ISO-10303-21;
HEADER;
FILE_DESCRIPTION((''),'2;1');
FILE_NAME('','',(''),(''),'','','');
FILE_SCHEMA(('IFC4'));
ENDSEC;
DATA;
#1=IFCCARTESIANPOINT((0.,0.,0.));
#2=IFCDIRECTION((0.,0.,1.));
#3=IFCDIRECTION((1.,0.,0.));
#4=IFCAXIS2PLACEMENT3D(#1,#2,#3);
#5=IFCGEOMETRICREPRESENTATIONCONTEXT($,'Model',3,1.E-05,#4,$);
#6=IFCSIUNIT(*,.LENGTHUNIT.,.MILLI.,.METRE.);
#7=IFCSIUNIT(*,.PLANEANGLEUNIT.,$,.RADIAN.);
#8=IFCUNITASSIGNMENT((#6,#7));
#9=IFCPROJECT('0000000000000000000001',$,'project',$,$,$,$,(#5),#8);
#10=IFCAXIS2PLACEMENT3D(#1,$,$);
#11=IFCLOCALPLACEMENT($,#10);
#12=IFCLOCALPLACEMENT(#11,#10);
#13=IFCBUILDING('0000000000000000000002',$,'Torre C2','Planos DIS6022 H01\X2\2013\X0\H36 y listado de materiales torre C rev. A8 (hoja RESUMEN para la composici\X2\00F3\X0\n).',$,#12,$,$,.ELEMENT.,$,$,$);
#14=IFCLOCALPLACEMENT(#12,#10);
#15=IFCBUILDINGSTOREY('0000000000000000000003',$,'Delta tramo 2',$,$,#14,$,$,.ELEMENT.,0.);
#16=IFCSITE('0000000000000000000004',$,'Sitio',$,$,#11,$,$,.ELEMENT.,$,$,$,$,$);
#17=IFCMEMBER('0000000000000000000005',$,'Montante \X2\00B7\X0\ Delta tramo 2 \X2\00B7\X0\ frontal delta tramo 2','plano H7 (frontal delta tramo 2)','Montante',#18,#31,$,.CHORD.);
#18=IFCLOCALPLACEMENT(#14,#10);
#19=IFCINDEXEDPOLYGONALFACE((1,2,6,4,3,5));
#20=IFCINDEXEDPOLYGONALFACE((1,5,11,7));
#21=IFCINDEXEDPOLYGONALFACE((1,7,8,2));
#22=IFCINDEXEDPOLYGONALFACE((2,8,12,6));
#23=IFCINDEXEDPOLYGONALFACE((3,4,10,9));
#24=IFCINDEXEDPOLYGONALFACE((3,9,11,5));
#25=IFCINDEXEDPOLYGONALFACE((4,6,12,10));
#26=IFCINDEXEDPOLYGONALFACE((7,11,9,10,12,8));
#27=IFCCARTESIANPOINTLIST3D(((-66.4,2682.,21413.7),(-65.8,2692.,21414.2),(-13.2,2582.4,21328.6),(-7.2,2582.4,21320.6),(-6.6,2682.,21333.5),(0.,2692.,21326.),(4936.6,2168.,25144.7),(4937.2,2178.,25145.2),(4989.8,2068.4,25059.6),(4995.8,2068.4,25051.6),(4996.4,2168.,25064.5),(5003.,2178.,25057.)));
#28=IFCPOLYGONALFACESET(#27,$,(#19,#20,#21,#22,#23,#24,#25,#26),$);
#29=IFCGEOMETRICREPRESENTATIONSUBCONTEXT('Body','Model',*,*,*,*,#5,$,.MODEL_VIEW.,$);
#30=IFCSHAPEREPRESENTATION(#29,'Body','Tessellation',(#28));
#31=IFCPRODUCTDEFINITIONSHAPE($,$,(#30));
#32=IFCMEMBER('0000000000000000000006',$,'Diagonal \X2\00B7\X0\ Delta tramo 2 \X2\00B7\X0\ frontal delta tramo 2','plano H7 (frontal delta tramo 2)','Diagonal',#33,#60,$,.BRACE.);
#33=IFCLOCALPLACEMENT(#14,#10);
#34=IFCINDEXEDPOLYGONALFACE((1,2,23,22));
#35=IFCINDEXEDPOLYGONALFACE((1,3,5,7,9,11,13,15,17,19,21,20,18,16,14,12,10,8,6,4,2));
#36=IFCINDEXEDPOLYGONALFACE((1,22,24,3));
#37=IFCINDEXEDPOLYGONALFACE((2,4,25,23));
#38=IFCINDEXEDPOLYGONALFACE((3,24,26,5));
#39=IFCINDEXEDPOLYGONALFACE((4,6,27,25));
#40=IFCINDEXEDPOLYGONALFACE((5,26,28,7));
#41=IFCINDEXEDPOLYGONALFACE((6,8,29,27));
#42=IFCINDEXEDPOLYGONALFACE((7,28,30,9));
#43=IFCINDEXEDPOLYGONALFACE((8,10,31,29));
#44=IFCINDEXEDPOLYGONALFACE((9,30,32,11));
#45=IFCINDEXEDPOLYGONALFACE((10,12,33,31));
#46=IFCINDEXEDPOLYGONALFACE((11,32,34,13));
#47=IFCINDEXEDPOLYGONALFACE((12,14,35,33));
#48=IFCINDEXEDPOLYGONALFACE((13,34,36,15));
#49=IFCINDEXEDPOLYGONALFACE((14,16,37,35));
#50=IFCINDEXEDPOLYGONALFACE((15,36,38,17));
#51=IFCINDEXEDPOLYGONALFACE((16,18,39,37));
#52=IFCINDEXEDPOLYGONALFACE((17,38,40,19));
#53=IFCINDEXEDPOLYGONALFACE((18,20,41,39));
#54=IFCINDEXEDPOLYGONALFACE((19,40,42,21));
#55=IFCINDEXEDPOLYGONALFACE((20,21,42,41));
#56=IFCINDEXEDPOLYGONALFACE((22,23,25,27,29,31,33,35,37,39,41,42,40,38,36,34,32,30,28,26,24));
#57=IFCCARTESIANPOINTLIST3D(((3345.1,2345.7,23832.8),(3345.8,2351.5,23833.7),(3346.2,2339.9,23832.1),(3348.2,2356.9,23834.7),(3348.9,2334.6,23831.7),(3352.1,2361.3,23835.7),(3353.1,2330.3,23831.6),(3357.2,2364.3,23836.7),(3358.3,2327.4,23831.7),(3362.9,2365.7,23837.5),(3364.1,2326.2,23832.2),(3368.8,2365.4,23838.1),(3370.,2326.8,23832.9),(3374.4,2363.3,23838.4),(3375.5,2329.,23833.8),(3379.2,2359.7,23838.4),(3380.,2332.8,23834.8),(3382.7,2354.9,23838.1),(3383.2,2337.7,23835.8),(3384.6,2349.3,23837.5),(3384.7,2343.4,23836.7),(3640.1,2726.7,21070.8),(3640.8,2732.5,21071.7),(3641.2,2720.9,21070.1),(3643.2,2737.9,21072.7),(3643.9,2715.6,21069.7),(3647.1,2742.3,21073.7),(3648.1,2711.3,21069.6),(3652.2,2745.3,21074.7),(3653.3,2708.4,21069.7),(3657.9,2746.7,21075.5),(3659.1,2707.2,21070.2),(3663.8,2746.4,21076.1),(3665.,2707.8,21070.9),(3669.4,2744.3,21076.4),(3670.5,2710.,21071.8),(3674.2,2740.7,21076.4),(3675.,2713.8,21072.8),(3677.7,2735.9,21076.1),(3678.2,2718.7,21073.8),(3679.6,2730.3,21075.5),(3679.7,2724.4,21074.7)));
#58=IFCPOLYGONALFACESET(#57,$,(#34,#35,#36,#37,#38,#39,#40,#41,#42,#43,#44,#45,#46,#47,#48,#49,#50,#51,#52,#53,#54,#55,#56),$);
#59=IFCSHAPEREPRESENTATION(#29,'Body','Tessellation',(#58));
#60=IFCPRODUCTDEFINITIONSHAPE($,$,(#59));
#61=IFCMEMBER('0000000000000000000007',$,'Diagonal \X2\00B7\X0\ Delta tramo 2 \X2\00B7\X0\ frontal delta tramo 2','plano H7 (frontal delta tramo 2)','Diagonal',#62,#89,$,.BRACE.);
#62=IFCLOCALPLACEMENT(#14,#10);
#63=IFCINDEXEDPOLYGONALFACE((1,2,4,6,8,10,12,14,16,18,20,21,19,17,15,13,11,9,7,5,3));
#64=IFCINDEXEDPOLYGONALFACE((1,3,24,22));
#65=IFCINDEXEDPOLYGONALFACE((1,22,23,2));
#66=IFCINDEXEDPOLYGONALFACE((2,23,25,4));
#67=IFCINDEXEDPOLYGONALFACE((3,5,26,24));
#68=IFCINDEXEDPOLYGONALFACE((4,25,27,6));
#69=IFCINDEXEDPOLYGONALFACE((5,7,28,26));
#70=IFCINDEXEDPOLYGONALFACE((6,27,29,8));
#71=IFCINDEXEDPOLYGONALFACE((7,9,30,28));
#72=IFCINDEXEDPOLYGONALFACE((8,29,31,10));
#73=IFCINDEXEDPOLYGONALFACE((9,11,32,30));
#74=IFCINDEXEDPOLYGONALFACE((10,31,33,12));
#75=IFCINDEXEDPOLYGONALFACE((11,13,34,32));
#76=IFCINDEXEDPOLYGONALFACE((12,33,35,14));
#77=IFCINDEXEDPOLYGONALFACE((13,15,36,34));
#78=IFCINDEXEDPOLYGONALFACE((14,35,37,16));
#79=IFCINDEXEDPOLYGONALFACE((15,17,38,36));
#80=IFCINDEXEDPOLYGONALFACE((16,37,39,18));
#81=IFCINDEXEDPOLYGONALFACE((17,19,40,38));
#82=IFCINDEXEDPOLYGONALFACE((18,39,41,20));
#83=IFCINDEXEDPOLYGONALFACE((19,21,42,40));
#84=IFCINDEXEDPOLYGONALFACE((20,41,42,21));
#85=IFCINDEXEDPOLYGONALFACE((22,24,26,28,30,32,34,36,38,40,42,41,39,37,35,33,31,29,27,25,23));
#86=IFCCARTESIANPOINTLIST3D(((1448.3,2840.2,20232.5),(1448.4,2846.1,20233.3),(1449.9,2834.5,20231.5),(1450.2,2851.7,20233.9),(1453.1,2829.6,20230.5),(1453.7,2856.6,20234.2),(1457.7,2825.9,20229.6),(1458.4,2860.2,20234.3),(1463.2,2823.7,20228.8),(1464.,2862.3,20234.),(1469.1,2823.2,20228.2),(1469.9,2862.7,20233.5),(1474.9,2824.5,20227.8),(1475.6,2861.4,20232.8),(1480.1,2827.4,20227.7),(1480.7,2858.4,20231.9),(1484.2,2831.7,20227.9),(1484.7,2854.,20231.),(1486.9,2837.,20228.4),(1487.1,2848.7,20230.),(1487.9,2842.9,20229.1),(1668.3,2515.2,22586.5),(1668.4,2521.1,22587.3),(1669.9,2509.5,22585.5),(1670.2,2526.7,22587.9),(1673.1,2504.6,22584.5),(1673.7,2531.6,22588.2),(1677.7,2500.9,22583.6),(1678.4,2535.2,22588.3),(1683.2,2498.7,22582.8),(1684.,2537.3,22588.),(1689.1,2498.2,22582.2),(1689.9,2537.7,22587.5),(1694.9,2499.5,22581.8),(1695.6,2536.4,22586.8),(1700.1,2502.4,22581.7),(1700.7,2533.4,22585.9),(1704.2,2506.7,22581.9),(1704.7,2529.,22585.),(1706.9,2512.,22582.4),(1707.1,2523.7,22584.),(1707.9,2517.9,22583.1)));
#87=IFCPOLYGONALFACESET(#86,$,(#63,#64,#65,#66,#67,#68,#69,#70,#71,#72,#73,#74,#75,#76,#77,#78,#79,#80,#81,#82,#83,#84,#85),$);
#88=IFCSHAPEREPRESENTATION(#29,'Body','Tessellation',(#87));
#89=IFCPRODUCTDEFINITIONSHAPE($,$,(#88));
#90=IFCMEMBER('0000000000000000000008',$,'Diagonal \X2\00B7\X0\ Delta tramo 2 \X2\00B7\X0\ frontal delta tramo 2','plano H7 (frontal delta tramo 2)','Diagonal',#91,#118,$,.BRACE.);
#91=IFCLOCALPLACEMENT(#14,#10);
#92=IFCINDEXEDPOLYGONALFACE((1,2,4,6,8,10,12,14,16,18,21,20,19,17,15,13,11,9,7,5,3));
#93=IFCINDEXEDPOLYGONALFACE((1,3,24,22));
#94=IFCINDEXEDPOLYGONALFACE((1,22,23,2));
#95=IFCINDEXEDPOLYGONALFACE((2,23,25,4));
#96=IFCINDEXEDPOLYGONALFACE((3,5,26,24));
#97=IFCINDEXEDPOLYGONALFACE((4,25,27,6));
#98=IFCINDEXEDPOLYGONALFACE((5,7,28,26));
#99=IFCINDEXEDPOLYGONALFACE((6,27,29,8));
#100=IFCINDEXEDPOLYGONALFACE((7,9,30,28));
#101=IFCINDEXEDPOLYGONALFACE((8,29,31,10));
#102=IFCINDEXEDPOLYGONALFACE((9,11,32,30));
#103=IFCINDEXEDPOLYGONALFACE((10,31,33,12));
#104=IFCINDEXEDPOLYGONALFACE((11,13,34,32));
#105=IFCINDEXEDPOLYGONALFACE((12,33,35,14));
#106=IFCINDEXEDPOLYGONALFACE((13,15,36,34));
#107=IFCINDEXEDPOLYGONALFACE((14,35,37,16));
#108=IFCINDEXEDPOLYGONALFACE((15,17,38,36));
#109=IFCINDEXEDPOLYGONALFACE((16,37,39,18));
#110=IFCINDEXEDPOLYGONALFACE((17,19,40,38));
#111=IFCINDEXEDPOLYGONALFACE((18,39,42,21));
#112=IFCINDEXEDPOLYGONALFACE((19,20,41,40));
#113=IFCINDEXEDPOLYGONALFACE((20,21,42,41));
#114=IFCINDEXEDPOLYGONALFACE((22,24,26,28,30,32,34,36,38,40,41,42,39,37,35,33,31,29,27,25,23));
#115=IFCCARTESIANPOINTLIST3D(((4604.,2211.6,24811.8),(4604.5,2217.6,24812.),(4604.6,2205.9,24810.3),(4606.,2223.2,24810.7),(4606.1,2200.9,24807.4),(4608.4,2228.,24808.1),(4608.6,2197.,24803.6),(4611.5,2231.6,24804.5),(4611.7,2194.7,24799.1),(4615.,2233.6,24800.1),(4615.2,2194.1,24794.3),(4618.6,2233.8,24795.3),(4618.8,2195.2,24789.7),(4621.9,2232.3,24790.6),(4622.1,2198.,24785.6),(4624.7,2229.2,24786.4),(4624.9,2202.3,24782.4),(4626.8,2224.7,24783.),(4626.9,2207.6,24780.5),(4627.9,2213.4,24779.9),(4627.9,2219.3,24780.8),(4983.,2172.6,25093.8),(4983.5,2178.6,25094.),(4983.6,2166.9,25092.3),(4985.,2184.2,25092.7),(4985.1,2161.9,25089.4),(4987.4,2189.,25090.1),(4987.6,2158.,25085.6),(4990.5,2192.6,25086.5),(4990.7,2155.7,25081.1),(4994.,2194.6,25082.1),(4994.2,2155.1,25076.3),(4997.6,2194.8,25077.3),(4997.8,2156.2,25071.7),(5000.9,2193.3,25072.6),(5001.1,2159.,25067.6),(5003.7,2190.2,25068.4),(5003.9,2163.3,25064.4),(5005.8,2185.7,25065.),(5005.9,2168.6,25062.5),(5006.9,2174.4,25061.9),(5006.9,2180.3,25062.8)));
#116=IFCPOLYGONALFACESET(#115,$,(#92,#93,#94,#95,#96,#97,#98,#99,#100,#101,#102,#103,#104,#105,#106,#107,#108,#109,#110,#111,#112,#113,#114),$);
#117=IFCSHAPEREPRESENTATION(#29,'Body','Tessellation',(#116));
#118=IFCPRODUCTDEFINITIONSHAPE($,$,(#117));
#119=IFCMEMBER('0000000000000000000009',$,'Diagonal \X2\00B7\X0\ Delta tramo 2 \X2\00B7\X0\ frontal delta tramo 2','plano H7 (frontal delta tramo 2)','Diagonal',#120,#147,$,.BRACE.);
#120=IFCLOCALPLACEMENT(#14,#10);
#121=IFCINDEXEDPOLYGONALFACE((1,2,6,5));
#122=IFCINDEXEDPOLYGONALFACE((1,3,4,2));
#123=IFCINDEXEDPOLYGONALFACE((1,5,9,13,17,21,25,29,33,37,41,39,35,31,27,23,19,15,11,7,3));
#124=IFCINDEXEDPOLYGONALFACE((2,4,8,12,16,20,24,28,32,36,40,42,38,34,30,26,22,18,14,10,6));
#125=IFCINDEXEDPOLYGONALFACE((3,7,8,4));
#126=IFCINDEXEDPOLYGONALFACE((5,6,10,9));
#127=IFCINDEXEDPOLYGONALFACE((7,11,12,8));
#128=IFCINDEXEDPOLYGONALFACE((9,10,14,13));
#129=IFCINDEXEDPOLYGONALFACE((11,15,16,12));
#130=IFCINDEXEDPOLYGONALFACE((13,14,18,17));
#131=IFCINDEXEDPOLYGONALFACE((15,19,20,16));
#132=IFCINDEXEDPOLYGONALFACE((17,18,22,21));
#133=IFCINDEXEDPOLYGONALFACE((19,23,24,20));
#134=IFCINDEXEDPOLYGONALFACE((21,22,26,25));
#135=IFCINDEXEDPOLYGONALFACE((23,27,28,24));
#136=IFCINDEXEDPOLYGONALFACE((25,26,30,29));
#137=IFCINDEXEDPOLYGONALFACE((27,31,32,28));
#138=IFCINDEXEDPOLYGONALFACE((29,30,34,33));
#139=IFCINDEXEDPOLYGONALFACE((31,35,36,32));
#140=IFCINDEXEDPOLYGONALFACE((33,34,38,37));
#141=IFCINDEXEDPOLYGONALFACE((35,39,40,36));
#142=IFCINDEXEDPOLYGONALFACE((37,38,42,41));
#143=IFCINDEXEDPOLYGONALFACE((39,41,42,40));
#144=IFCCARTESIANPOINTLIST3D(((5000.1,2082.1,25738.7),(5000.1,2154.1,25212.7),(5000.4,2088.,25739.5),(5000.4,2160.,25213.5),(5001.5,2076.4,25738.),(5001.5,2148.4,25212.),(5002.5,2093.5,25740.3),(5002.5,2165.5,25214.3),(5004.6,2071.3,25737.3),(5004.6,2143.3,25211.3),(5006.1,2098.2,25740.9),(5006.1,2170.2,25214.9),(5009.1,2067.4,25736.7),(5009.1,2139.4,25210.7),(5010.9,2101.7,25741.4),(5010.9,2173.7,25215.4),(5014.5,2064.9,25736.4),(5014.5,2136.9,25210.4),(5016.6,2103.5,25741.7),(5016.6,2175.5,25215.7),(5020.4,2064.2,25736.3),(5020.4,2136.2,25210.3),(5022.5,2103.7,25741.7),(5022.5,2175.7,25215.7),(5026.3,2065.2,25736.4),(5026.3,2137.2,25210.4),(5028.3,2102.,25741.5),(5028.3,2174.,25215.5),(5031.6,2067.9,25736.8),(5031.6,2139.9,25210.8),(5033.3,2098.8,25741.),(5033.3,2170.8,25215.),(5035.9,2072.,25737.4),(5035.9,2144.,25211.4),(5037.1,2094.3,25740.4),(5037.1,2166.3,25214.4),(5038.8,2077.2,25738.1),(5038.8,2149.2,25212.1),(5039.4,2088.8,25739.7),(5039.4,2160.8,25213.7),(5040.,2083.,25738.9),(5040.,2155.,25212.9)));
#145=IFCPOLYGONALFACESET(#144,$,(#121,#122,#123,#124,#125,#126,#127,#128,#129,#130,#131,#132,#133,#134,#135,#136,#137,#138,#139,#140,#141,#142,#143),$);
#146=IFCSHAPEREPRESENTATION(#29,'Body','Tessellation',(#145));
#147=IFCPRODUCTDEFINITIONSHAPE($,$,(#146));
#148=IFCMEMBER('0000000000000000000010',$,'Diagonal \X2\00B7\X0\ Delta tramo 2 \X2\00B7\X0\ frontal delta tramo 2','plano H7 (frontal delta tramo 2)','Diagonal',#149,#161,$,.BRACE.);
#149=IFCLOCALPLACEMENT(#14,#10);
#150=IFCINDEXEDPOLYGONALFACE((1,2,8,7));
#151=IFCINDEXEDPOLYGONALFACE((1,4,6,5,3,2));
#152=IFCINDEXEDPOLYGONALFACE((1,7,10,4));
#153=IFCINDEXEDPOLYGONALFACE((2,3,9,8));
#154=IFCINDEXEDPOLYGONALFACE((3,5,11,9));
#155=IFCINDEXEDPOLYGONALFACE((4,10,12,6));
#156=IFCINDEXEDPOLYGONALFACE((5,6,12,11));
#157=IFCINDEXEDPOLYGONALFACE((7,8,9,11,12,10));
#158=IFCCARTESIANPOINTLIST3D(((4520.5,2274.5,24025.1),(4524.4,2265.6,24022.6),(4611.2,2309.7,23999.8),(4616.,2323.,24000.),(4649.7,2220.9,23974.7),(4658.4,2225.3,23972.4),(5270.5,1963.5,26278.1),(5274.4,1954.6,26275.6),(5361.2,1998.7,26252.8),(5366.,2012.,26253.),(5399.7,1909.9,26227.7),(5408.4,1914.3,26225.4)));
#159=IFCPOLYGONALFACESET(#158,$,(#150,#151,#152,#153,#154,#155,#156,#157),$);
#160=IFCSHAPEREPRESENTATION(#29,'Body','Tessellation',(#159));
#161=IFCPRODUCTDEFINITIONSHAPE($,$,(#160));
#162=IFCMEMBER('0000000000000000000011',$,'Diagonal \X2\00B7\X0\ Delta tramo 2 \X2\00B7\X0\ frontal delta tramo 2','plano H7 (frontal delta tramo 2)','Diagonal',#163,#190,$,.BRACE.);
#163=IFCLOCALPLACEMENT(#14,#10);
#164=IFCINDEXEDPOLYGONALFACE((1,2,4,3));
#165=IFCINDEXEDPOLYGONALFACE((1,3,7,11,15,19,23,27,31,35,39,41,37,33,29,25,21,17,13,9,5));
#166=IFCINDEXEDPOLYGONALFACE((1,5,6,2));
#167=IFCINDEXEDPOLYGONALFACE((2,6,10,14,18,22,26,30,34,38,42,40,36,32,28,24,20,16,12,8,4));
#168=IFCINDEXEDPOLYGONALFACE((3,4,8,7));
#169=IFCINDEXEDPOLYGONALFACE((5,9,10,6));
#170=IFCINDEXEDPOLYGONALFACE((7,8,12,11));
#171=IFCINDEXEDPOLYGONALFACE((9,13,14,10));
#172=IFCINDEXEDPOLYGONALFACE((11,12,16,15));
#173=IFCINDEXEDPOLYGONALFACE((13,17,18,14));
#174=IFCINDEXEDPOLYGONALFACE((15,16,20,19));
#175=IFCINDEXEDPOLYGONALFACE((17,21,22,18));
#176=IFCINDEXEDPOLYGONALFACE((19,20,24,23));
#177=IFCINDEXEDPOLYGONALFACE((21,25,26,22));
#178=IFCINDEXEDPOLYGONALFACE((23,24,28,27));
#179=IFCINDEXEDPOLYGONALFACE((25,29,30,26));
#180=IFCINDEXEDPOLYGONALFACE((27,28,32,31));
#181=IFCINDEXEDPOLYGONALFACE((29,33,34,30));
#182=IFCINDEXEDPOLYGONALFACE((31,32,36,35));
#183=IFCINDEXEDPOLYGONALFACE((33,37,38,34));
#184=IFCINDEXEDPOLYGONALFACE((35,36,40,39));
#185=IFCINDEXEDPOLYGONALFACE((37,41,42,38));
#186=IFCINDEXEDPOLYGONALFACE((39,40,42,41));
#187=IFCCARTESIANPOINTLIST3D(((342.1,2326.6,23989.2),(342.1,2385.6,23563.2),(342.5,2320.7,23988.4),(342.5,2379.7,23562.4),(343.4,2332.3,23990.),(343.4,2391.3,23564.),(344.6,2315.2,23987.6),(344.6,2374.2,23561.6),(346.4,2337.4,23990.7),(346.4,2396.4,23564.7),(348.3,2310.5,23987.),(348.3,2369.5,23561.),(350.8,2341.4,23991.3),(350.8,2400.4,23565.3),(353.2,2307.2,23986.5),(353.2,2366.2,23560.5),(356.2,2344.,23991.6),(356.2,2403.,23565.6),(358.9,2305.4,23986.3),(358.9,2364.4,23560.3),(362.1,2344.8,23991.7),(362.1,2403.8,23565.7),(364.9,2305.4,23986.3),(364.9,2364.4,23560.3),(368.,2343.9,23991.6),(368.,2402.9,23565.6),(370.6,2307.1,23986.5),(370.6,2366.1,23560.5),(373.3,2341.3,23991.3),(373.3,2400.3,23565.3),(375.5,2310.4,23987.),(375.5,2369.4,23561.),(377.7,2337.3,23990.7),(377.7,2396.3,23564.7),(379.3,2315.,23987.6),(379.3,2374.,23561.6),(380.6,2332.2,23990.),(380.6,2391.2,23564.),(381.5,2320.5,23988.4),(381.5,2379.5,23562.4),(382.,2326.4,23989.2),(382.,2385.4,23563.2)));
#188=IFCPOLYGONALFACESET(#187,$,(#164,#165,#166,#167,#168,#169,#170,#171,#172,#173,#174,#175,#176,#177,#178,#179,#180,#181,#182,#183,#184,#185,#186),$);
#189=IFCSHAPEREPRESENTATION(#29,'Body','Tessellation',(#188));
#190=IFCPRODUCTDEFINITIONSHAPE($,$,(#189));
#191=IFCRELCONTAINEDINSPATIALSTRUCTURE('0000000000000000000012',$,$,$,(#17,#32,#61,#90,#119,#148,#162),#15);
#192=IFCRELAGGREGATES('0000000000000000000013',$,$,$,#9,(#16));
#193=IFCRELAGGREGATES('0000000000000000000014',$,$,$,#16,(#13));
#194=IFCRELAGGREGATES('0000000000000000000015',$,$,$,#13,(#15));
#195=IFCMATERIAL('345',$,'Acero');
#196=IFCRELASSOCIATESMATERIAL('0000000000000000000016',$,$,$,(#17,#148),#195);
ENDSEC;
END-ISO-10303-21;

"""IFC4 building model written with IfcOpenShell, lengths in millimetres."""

from ifc_helpers import new_model, si_unit, frame, frame_2d, origin, origin_with_axes, place, context, subcontext, project, spatial, circle, l_section, extrude, material, element, save


model = new_model("IFC4")

# Units and contexts
model_context = context("Model", 3, precision=1e-05, world=origin_with_axes())
body_context = subcontext(model_context, "Body", "Model", "MODEL_VIEW")
ifc_project = project(units=[si_unit("LENGTHUNIT", "METRE", prefix="MILLI"), si_unit("PLANEANGLEUNIT", "RADIAN")], contexts=[model_context])

# Site, building, storey
site_placement = place(None, origin())
site = spatial("IfcSite", under=ifc_project, at=site_placement, Name="Sitio", CompositionType="ELEMENT")
building_placement = place(site_placement, origin())
building = spatial("IfcBuilding", under=site, at=building_placement, Name="Torre C2", Description="Planos DIS6022 H01–H36 y listado de materiales torre C rev. A8 (hoja RESUMEN para la composición).", CompositionType="ELEMENT")
storey_placement = place(building_placement, origin())
storey = spatial("IfcBuildingStorey", under=building, at=storey_placement, Name="Delta tramo 2", CompositionType="ELEMENT", Elevation=0.0)

# Members
ifc_material_1 = material(Name="345", Category="Acero")
member_1_placement = place(storey_placement, frame((5003.0, 2178.0, 25057.0), z_axis=(-0.798926, 0.08208, -0.595801), x_axis=(-0.065798, -0.996626, -0.049069)))
element("IfcMember", 1, at=member_1_placement, inside=storey, material=ifc_material_1, Name="Montante · Delta tramo 2 · frontal delta tramo 2", Description="plano H7 (frontal delta tramo 2)", ObjectType="Montante", PredefinedType="CHORD", context=body_context, shape_type="SweptSolid", body=[
    extrude(l_section(Depth=110.0, Width=110.0, Thickness=10.0, at=frame_2d((55.0, 55.0))), None, (0.0, 0.0, 1.0), 6262.2),
])
member_2_placement = place(storey_placement, frame((3365.0, 2346.0, 23835.0), z_axis=(0.105217, 0.135891, -0.985121), x_axis=(-0.804373, -0.570852, -0.164658)))
element("IfcMember", 2, at=member_2_placement, inside=storey, Name="Diagonal · Delta tramo 2 · frontal delta tramo 2", Description="plano H7 (frontal delta tramo 2)", ObjectType="Diagonal", PredefinedType="BRACE", context=body_context, shape_type="SweptSolid", body=[
    extrude(circle(Radius=20.0), None, (0.0, 0.0, 1.0), 2803.7),
])
member_3_placement = place(storey_placement, frame((1688.0, 2518.0, 22585.0), z_axis=(-0.092186, 0.136183, -0.986385), x_axis=(-0.515108, -0.854278, -0.069803)))
element("IfcMember", 3, at=member_3_placement, inside=storey, Name="Diagonal · Delta tramo 2 · frontal delta tramo 2", Description="plano H7 (frontal delta tramo 2)", ObjectType="Diagonal", PredefinedType="BRACE", context=body_context, shape_type="SweptSolid", body=[
    extrude(circle(Radius=20.0), None, (0.0, 0.0, 1.0), 2386.5),
])
member_4_placement = place(storey_placement, frame((4995.0, 2175.0, 25078.0), z_axis=(-0.79956, 0.082277, -0.594923), x_axis=(-0.493108, -0.655414, 0.572081)))
element("IfcMember", 4, at=member_4_placement, inside=storey, Name="Diagonal · Delta tramo 2 · frontal delta tramo 2", Description="plano H7 (frontal delta tramo 2)", ObjectType="Diagonal", PredefinedType="BRACE", context=body_context, shape_type="SweptSolid", body=[
    extrude(circle(Radius=20.0), None, (0.0, 0.0, 1.0), 474.0),
])
member_5_placement = place(storey_placement, frame((5020.0, 2156.0, 25213.0), z_axis=(0.0, -0.135618, 0.990761), x_axis=(-0.922505, -0.382419, -0.052346)))
element("IfcMember", 5, at=member_5_placement, inside=storey, Name="Diagonal · Delta tramo 2 · frontal delta tramo 2", Description="plano H7 (frontal delta tramo 2)", ObjectType="Diagonal", PredefinedType="BRACE", context=body_context, shape_type="SweptSolid", body=[
    extrude(circle(Radius=20.0), None, (0.0, 0.0, 1.0), 530.9),
])
member_6_placement = place(storey_placement, frame((4616.0, 2323.0, 24000.0), z_axis=(0.313174, -0.129863, 0.940775), x_axis=(-0.867893, -0.441341, 0.22799)))
element("IfcMember", 6, at=member_6_placement, inside=storey, material=ifc_material_1, Name="Diagonal · Delta tramo 2 · frontal delta tramo 2", Description="plano H7 (frontal delta tramo 2)", ObjectType="Diagonal", PredefinedType="BRACE", context=body_context, shape_type="SweptSolid", body=[
    extrude(l_section(Depth=110.0, Width=110.0, Thickness=10.0, at=frame_2d((55.0, 55.0))), None, (0.0, 0.0, 1.0), 2394.8),
])
for number, where, z_axis, x_axis, name in (
    (7, (362.0, 2384.0, 23563.0), (0.0, -0.137188, 0.990545), (-0.153379, -0.978824, -0.135565), "Diagonal · Delta tramo 2 · frontal delta tramo 2"),
):
    element("IfcMember", number, at=place(storey_placement, frame(where, z_axis=z_axis, x_axis=x_axis)), inside=storey, Name=name, Description="plano H7 (frontal delta tramo 2)", ObjectType="Diagonal", PredefinedType="BRACE", context=body_context, shape_type="SweptSolid", body=[
        extrude(circle(Radius=20.0), None, (0.0, 0.0, 1.0), 430.1),
    ])

save(model, "model.ifc")
